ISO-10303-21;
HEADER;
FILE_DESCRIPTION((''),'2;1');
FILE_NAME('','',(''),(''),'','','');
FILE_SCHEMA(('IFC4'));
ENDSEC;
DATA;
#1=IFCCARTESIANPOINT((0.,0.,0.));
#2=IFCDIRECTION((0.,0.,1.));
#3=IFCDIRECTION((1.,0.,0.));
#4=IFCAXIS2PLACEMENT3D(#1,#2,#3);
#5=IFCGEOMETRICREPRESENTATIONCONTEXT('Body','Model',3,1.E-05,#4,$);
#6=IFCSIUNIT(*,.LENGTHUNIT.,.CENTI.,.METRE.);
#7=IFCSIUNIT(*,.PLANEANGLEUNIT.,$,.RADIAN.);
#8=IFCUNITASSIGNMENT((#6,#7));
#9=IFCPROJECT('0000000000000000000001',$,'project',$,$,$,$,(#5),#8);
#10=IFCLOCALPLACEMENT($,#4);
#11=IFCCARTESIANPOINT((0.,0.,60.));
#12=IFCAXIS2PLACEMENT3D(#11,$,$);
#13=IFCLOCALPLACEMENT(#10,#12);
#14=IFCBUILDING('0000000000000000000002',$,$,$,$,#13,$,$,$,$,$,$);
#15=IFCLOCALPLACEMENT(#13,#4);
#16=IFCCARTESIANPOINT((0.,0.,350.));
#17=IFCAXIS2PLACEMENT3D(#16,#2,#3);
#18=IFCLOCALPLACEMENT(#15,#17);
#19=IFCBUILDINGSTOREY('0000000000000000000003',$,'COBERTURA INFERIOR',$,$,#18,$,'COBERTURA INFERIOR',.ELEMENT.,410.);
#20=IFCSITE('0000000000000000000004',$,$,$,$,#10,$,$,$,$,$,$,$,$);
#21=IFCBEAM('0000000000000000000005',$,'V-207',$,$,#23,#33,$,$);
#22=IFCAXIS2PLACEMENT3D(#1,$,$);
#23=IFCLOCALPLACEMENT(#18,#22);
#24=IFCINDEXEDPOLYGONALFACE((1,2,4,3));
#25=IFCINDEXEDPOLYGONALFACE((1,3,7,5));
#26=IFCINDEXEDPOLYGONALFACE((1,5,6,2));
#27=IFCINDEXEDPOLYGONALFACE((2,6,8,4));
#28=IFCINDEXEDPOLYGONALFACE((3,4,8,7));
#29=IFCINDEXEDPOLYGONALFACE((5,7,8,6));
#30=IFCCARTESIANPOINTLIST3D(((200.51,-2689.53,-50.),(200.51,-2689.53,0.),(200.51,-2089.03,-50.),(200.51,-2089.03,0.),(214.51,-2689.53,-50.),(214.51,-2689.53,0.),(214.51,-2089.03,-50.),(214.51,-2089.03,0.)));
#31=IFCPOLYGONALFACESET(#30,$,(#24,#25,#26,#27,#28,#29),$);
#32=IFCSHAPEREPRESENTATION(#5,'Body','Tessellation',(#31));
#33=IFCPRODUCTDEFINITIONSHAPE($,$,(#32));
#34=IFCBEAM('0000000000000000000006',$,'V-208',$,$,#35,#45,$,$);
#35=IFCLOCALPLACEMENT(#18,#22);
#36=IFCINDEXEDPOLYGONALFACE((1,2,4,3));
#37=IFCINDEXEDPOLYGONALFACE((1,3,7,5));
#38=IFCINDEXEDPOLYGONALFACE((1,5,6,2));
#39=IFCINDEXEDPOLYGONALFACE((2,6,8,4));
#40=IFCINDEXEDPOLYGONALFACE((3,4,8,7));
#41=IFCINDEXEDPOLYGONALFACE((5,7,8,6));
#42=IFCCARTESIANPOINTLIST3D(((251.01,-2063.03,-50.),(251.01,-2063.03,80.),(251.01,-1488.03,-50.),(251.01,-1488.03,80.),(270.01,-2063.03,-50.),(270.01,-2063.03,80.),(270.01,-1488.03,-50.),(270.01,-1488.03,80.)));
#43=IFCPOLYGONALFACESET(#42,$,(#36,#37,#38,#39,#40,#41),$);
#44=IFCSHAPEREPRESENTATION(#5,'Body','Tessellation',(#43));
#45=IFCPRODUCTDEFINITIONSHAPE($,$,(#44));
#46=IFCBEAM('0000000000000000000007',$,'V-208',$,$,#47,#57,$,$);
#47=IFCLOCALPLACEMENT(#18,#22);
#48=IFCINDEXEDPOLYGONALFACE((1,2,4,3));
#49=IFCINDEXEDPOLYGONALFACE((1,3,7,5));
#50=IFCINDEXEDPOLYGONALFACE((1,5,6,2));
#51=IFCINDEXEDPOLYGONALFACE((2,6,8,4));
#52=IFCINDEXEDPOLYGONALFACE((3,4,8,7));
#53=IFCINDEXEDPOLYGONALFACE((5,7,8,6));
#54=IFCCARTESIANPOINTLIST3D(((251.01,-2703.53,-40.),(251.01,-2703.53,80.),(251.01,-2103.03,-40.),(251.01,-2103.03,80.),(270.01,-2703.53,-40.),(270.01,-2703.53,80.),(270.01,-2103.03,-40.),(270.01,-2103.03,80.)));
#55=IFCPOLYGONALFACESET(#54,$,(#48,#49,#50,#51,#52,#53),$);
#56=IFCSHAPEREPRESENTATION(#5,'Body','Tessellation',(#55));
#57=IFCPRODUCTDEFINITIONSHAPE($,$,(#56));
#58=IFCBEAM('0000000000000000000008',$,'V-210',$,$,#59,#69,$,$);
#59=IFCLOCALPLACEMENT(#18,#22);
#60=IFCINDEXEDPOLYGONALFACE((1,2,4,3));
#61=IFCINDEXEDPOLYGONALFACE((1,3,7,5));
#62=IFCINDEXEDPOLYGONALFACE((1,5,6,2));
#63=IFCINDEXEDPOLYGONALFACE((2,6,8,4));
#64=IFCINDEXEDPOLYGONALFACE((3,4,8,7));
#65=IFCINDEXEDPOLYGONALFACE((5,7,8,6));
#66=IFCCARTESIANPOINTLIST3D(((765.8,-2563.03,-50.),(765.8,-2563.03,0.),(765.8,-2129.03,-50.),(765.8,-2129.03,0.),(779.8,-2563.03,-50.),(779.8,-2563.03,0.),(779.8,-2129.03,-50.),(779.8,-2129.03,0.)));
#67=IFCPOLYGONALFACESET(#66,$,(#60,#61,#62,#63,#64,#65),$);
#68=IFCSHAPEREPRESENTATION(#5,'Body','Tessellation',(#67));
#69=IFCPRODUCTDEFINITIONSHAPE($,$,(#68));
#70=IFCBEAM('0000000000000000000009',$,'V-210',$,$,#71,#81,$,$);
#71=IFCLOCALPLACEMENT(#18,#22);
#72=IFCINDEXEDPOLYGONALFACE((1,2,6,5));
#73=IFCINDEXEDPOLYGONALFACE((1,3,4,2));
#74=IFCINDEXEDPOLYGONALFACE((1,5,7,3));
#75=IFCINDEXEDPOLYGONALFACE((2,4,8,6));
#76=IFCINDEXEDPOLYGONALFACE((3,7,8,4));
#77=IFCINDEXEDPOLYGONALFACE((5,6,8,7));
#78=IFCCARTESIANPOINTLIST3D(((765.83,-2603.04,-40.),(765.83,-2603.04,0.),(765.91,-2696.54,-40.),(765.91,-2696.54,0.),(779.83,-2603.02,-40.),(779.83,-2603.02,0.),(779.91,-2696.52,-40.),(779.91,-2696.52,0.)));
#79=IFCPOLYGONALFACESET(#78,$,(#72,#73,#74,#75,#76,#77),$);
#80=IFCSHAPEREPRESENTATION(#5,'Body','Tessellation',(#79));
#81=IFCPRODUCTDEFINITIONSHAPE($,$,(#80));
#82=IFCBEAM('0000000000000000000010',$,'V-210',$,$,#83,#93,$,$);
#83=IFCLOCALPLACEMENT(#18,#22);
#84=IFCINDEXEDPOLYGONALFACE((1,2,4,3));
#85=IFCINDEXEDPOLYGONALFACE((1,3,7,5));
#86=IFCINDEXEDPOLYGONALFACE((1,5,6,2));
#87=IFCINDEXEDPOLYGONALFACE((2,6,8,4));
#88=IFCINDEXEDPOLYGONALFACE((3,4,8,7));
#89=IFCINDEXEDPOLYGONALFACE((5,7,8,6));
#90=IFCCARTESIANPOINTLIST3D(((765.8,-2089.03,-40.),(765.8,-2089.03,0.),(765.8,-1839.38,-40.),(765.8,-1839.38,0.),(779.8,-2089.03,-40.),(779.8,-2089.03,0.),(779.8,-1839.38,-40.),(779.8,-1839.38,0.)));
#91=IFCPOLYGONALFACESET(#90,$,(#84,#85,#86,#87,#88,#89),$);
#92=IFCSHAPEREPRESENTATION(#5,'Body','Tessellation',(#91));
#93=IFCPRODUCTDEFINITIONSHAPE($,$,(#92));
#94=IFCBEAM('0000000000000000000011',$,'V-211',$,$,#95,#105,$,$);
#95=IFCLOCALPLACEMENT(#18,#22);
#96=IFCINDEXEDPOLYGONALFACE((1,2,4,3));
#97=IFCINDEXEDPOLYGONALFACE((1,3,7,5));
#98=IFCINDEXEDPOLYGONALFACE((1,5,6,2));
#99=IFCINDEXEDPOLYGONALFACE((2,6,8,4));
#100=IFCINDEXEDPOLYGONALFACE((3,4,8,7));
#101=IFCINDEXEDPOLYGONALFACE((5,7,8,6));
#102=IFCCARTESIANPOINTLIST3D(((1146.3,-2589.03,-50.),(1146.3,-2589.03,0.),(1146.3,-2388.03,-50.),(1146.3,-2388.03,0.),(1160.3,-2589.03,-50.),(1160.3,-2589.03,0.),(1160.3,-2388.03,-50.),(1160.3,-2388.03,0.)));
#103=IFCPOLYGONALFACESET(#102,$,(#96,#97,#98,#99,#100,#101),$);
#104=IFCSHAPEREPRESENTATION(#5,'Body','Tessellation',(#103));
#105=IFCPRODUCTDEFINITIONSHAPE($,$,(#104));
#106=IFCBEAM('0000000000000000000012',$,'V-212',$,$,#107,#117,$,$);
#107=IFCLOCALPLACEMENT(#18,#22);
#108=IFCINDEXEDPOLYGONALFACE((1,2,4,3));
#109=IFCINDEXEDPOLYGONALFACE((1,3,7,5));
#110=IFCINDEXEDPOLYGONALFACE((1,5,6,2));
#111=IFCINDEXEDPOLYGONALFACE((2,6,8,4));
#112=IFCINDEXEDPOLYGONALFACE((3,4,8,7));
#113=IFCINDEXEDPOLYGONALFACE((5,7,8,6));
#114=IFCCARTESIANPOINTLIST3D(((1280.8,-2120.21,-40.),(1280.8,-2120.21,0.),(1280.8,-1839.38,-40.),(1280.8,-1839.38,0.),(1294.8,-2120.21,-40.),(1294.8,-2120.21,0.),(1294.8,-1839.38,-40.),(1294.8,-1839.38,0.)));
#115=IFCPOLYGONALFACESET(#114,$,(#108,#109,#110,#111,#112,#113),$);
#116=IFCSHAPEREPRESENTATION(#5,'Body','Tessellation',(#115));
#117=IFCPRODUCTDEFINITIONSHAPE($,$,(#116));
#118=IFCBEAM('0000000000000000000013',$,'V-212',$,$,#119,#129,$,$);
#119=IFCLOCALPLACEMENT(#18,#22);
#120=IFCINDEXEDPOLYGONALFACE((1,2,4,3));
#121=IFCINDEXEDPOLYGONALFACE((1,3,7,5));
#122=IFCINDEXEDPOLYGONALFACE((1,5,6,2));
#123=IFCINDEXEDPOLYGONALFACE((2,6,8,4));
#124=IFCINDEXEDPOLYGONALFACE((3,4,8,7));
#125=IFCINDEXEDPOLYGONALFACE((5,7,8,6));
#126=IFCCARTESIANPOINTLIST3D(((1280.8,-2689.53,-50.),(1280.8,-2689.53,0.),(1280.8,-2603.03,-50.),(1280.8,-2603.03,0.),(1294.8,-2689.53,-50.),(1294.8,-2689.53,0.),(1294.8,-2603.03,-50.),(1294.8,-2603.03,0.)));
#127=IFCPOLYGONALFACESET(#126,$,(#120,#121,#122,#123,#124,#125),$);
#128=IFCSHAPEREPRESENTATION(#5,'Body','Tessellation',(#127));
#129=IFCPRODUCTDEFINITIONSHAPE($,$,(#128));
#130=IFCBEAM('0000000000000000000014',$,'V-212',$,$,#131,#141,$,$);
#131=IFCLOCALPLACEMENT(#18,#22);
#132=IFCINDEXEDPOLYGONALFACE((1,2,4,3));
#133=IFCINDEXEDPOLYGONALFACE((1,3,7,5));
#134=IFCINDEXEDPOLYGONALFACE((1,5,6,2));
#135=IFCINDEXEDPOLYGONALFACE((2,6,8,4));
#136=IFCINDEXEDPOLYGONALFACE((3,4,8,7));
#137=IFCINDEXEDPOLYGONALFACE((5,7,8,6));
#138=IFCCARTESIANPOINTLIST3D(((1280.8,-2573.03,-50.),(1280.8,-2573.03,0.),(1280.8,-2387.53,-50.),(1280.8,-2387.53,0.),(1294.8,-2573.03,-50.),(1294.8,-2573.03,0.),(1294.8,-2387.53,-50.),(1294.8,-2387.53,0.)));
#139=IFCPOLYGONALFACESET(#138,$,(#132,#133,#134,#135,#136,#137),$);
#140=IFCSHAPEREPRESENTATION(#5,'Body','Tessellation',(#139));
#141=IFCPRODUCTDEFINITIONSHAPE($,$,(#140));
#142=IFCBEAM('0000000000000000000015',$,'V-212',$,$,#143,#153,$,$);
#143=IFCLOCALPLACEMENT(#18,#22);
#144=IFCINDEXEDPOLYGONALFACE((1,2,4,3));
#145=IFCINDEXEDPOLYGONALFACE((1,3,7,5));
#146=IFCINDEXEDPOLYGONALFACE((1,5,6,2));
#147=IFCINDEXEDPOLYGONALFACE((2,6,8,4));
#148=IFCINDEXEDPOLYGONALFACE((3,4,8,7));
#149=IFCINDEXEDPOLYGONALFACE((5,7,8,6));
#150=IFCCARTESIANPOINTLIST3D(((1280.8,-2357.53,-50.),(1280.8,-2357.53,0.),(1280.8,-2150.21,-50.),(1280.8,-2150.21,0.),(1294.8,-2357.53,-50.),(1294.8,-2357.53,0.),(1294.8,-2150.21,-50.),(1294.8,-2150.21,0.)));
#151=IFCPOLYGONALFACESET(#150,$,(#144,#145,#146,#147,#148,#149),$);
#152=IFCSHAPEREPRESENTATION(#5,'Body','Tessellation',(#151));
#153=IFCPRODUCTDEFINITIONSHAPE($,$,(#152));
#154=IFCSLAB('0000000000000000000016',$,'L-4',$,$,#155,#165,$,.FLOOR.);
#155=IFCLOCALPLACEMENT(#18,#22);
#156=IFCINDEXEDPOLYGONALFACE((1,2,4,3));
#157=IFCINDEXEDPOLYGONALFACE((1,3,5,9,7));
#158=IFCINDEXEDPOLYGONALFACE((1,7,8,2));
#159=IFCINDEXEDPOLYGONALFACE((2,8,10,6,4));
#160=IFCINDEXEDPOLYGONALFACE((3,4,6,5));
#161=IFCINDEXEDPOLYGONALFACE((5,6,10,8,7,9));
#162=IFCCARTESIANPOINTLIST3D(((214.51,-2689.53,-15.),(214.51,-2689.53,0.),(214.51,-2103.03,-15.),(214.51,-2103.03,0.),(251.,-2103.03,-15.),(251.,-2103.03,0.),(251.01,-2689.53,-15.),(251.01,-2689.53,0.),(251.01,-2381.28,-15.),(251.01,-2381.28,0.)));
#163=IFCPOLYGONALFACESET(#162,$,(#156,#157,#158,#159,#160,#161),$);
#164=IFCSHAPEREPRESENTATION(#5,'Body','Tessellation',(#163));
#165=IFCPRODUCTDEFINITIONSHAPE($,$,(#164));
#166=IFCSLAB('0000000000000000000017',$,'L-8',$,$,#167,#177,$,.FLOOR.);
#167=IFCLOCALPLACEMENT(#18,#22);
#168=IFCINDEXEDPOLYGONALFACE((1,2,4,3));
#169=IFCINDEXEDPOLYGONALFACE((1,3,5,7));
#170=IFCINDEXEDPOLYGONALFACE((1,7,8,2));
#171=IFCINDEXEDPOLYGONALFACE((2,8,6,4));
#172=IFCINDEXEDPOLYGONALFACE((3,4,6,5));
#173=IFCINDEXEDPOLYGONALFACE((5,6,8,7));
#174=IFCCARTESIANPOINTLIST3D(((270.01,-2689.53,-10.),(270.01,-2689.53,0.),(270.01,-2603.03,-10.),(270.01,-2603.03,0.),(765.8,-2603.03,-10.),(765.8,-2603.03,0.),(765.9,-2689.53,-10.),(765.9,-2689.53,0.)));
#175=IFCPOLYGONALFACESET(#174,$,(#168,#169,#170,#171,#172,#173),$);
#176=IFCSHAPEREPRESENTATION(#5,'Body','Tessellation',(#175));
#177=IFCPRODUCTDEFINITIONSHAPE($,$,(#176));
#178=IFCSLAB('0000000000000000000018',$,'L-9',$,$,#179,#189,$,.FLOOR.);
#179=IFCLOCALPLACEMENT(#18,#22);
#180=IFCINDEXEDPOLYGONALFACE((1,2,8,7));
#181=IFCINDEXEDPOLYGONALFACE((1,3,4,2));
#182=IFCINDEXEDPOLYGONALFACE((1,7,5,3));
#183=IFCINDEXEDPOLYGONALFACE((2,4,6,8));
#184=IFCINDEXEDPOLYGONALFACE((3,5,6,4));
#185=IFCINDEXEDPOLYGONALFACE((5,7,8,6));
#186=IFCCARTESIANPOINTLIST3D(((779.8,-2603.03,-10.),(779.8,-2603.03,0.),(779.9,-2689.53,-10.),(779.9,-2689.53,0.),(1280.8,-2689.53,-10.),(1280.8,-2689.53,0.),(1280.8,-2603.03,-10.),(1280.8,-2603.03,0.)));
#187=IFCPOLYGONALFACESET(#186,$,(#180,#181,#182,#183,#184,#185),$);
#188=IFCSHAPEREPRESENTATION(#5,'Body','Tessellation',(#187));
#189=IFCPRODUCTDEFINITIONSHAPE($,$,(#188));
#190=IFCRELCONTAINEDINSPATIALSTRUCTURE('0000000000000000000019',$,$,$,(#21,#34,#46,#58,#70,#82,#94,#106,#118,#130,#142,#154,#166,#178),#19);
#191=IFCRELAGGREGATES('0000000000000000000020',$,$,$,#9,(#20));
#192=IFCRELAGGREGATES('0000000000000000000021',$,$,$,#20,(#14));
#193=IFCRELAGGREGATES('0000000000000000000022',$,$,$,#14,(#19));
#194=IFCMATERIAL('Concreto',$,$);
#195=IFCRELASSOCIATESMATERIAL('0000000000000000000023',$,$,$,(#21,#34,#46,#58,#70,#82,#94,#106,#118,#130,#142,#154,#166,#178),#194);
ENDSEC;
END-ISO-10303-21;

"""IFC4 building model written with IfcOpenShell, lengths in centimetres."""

from ifc_helpers import new_model, si_unit, frame, origin_with_axes, origin_2d_with_axis, place, context, project, spatial, polyline, rectangle, outline, extrude, material, element, save


model = new_model("IFC4")

# Units and contexts
model_context = context("Model", 3, precision=1e-05, world=origin_with_axes(), identifier="Body")
ifc_project = project(units=[si_unit("LENGTHUNIT", "METRE", prefix="CENTI"), si_unit("PLANEANGLEUNIT", "RADIAN")], contexts=[model_context])

# Site, building, storey
site_placement = place(None, origin_with_axes())
site = spatial("IfcSite", under=ifc_project, at=site_placement)
building_placement = place(site_placement, frame((0.0, 0.0, 60.0)))
building = spatial("IfcBuilding", under=site, at=building_placement)
placement = place(building_placement, origin_with_axes())
storey_placement = place(placement, frame((0.0, 0.0, 350.0), z_axis=(0.0, 0.0, 1.0), x_axis=(1.0, 0.0, 0.0)))
storey = spatial("IfcBuildingStorey", under=building, at=storey_placement, Name="COBERTURA INFERIOR", LongName="COBERTURA INFERIOR", CompositionType="ELEMENT", Elevation=410.0)

# Shared definitions
ifc_material = material(Name="Concreto")

# Beams
beam_1_placement = place(storey_placement, frame((207.51, -2389.28, 0.0), z_axis=(0.0, 0.0, 1.0), x_axis=(1.0, 0.0, 0.0)))
element("IfcBeam", 1, at=beam_1_placement, inside=storey, material=ifc_material, Name="V-207", context=model_context, shape_type="SolidModel", body=[
    extrude(rectangle(XDim=14.0, YDim=50.0, at=origin_2d_with_axis()), frame((0.0, -300.25, -25.0), z_axis=(0.0, 1.0, 0.0), x_axis=(1.0, 0.0, 0.0)), (0.0, 0.0, 1.0), 600.5),
])
beam_2_placement = place(storey_placement, frame((260.51, -1775.53, 80.0), z_axis=(0.0, 0.0, 1.0), x_axis=(1.0, 0.0, 0.0)))
element("IfcBeam", 2, at=beam_2_placement, inside=storey, material=ifc_material, Name="V-208", context=model_context, shape_type="SolidModel", body=[
    extrude(rectangle(XDim=19.0, YDim=130.0, at=origin_2d_with_axis()), frame((0.0, -287.5, -65.0), z_axis=(0.0, 1.0, 0.0), x_axis=(1.0, 0.0, 0.0)), (0.0, 0.0, 1.0), 575.0),
])
beam_3_placement = place(storey_placement, frame((260.51, -2403.28, 80.0), z_axis=(0.0, 0.0, 1.0), x_axis=(1.0, 0.0, 0.0)))
element("IfcBeam", 3, at=beam_3_placement, inside=storey, material=ifc_material, Name="V-208", context=model_context, shape_type="SolidModel", body=[
    extrude(rectangle(XDim=19.0, YDim=120.0, at=origin_2d_with_axis()), frame((0.0, -300.25, -60.0), z_axis=(0.0, 1.0, 0.0), x_axis=(1.0, 0.0, 0.0)), (0.0, 0.0, 1.0), 600.5),
])
beam_4_placement = place(storey_placement, frame((772.8, -2346.03, 0.0), z_axis=(0.0, 0.0, 1.0), x_axis=(1.0, 0.0, 0.0)))
element("IfcBeam", 4, at=beam_4_placement, inside=storey, material=ifc_material, Name="V-210", context=model_context, shape_type="SolidModel", body=[
    extrude(rectangle(XDim=14.0, YDim=50.0, at=origin_2d_with_axis()), frame((0.0, -217.0, -25.0), z_axis=(0.0, 1.0, 0.0), x_axis=(1.0, 0.0, 0.0)), (0.0, 0.0, 1.0), 434.0),
])
beam_5_placement = place(storey_placement, frame((772.87, -2649.78, 0.0), z_axis=(0.0, 0.0, 1.0), x_axis=(1.0, 0.0, 0.0)))
element("IfcBeam", 5, at=beam_5_placement, inside=storey, material=ifc_material, Name="V-210", context=model_context, shape_type="SolidModel", body=[
    extrude(rectangle(XDim=14.0, YDim=40.0, at=origin_2d_with_axis()), frame((0.04, -46.75, -20.0), z_axis=(-0.000856, 1.0, 0.0), x_axis=(1.0, 0.000856, 0.0)), (0.0, 0.0, 1.0), 93.5),
])
beam_6_placement = place(storey_placement, frame((772.8, -1964.2, 0.0), z_axis=(0.0, 0.0, 1.0), x_axis=(1.0, 0.0, 0.0)))
element("IfcBeam", 6, at=beam_6_placement, inside=storey, material=ifc_material, Name="V-210", context=model_context, shape_type="SolidModel", body=[
    extrude(rectangle(XDim=14.0, YDim=40.0, at=origin_2d_with_axis()), frame((0.0, -124.83, -20.0), z_axis=(0.0, 1.0, 0.0), x_axis=(1.0, 0.0, 0.0)), (0.0, 0.0, 1.0), 249.65),
])
beam_7_placement = place(storey_placement, frame((1153.3, -2488.53, 0.0), z_axis=(0.0, 0.0, 1.0), x_axis=(1.0, 0.0, 0.0)))
element("IfcBeam", 7, at=beam_7_placement, inside=storey, material=ifc_material, Name="V-211", context=model_context, shape_type="SolidModel", body=[
    extrude(rectangle(XDim=14.0, YDim=50.0, at=origin_2d_with_axis()), frame((0.0, -100.5, -25.0), z_axis=(0.0, 1.0, 0.0), x_axis=(1.0, 0.0, 0.0)), (0.0, 0.0, 1.0), 201.0),
])
beam_8_placement = place(storey_placement, frame((1287.8, -1979.8, 0.0), z_axis=(0.0, 0.0, 1.0), x_axis=(1.0, 0.0, 0.0)))
element("IfcBeam", 8, at=beam_8_placement, inside=storey, material=ifc_material, Name="V-212", context=model_context, shape_type="SolidModel", body=[
    extrude(rectangle(XDim=14.0, YDim=40.0, at=origin_2d_with_axis()), frame((0.0, -140.41, -20.0), z_axis=(0.0, 1.0, 0.0), x_axis=(1.0, 0.0, 0.0)), (0.0, 0.0, 1.0), 280.83),
])
beam_9_placement = place(storey_placement, frame((1287.8, -2646.28, 0.0), z_axis=(0.0, 0.0, 1.0), x_axis=(1.0, 0.0, 0.0)))
element("IfcBeam", 9, at=beam_9_placement, inside=storey, material=ifc_material, Name="V-212", context=model_context, shape_type="SolidModel", body=[
    extrude(rectangle(XDim=14.0, YDim=50.0, at=origin_2d_with_axis()), frame((0.0, -43.25, -25.0), z_axis=(0.0, 1.0, 0.0), x_axis=(1.0, 0.0, 0.0)), (0.0, 0.0, 1.0), 86.5),
])
beam_10_placement = place(storey_placement, frame((1287.8, -2480.28, 0.0), z_axis=(0.0, 0.0, 1.0), x_axis=(1.0, 0.0, 0.0)))
element("IfcBeam", 10, at=beam_10_placement, inside=storey, material=ifc_material, Name="V-212", context=model_context, shape_type="SolidModel", body=[
    extrude(rectangle(XDim=14.0, YDim=50.0, at=origin_2d_with_axis()), frame((0.0, -92.75, -25.0), z_axis=(0.0, 1.0, 0.0), x_axis=(1.0, 0.0, 0.0)), (0.0, 0.0, 1.0), 185.5),
])
beam_11_placement = place(storey_placement, frame((1287.8, -2253.87, 0.0), z_axis=(0.0, 0.0, 1.0), x_axis=(1.0, 0.0, 0.0)))
element("IfcBeam", 11, at=beam_11_placement, inside=storey, material=ifc_material, Name="V-212", context=model_context, shape_type="SolidModel", body=[
    extrude(rectangle(XDim=14.0, YDim=50.0, at=origin_2d_with_axis()), frame((0.0, -103.66, -25.0), z_axis=(0.0, 1.0, 0.0), x_axis=(1.0, 0.0, 0.0)), (0.0, 0.0, 1.0), 207.32),
])

# Slabs
slab_1_placement = place(storey_placement, frame((232.76, -2396.28, 0.0), z_axis=(0.0, 0.0, 1.0), x_axis=(1.0, 0.0, 0.0)))
element("IfcSlab", 12, at=slab_1_placement, inside=storey, material=ifc_material, Name="L-4", PredefinedType="FLOOR", context=model_context, shape_type="SolidModel", body=[
    extrude(outline(polyline([(18.25, -293.25), (18.25, 15.0), (18.24, 293.25), (-18.25, 293.25), (-18.25, -293.25), (18.25, -293.25), (18.25, -293.25)])), frame((0.0, 0.0, -15.0), z_axis=(0.0, 0.0, 1.0), x_axis=(1.0, 0.0, 0.0)), (0.0, 0.0, 1.0), 15.0),
])
slab_2_placement = place(storey_placement, frame((517.96, -2646.28, 0.0), z_axis=(0.0, 0.0, 1.0), x_axis=(1.0, 0.0, 0.0)))
element("IfcSlab", 13, at=slab_2_placement, inside=storey, material=ifc_material, Name="L-8", PredefinedType="FLOOR", context=model_context, shape_type="SolidModel", body=[
    extrude(outline(polyline([(247.84, 43.25), (-247.94, 43.25), (-247.94, -43.25), (247.95, -43.25), (247.84, 43.25), (247.84, 43.25)])), frame((0.0, 0.0, -10.0), z_axis=(0.0, 0.0, 1.0), x_axis=(1.0, 0.0, 0.0)), (0.0, 0.0, 1.0), 10.0),
])
slab_3_placement = place(storey_placement, frame((1030.3, -2646.28, 0.0), z_axis=(0.0, 0.0, 1.0), x_axis=(1.0, 0.0, 0.0)))
element("IfcSlab", 14, at=slab_3_placement, inside=storey, material=ifc_material, Name="L-9", PredefinedType="FLOOR", context=model_context, shape_type="SolidModel", body=[
    extrude(outline(polyline([(250.5, 43.25), (-250.5, 43.25), (-250.4, -43.25), (250.5, -43.25), (250.5, 43.25), (250.5, 43.25)])), frame((0.0, 0.0, -10.0), z_axis=(0.0, 0.0, 1.0), x_axis=(1.0, 0.0, 0.0)), (0.0, 0.0, 1.0), 10.0),
])

save(model, "model.ifc")
